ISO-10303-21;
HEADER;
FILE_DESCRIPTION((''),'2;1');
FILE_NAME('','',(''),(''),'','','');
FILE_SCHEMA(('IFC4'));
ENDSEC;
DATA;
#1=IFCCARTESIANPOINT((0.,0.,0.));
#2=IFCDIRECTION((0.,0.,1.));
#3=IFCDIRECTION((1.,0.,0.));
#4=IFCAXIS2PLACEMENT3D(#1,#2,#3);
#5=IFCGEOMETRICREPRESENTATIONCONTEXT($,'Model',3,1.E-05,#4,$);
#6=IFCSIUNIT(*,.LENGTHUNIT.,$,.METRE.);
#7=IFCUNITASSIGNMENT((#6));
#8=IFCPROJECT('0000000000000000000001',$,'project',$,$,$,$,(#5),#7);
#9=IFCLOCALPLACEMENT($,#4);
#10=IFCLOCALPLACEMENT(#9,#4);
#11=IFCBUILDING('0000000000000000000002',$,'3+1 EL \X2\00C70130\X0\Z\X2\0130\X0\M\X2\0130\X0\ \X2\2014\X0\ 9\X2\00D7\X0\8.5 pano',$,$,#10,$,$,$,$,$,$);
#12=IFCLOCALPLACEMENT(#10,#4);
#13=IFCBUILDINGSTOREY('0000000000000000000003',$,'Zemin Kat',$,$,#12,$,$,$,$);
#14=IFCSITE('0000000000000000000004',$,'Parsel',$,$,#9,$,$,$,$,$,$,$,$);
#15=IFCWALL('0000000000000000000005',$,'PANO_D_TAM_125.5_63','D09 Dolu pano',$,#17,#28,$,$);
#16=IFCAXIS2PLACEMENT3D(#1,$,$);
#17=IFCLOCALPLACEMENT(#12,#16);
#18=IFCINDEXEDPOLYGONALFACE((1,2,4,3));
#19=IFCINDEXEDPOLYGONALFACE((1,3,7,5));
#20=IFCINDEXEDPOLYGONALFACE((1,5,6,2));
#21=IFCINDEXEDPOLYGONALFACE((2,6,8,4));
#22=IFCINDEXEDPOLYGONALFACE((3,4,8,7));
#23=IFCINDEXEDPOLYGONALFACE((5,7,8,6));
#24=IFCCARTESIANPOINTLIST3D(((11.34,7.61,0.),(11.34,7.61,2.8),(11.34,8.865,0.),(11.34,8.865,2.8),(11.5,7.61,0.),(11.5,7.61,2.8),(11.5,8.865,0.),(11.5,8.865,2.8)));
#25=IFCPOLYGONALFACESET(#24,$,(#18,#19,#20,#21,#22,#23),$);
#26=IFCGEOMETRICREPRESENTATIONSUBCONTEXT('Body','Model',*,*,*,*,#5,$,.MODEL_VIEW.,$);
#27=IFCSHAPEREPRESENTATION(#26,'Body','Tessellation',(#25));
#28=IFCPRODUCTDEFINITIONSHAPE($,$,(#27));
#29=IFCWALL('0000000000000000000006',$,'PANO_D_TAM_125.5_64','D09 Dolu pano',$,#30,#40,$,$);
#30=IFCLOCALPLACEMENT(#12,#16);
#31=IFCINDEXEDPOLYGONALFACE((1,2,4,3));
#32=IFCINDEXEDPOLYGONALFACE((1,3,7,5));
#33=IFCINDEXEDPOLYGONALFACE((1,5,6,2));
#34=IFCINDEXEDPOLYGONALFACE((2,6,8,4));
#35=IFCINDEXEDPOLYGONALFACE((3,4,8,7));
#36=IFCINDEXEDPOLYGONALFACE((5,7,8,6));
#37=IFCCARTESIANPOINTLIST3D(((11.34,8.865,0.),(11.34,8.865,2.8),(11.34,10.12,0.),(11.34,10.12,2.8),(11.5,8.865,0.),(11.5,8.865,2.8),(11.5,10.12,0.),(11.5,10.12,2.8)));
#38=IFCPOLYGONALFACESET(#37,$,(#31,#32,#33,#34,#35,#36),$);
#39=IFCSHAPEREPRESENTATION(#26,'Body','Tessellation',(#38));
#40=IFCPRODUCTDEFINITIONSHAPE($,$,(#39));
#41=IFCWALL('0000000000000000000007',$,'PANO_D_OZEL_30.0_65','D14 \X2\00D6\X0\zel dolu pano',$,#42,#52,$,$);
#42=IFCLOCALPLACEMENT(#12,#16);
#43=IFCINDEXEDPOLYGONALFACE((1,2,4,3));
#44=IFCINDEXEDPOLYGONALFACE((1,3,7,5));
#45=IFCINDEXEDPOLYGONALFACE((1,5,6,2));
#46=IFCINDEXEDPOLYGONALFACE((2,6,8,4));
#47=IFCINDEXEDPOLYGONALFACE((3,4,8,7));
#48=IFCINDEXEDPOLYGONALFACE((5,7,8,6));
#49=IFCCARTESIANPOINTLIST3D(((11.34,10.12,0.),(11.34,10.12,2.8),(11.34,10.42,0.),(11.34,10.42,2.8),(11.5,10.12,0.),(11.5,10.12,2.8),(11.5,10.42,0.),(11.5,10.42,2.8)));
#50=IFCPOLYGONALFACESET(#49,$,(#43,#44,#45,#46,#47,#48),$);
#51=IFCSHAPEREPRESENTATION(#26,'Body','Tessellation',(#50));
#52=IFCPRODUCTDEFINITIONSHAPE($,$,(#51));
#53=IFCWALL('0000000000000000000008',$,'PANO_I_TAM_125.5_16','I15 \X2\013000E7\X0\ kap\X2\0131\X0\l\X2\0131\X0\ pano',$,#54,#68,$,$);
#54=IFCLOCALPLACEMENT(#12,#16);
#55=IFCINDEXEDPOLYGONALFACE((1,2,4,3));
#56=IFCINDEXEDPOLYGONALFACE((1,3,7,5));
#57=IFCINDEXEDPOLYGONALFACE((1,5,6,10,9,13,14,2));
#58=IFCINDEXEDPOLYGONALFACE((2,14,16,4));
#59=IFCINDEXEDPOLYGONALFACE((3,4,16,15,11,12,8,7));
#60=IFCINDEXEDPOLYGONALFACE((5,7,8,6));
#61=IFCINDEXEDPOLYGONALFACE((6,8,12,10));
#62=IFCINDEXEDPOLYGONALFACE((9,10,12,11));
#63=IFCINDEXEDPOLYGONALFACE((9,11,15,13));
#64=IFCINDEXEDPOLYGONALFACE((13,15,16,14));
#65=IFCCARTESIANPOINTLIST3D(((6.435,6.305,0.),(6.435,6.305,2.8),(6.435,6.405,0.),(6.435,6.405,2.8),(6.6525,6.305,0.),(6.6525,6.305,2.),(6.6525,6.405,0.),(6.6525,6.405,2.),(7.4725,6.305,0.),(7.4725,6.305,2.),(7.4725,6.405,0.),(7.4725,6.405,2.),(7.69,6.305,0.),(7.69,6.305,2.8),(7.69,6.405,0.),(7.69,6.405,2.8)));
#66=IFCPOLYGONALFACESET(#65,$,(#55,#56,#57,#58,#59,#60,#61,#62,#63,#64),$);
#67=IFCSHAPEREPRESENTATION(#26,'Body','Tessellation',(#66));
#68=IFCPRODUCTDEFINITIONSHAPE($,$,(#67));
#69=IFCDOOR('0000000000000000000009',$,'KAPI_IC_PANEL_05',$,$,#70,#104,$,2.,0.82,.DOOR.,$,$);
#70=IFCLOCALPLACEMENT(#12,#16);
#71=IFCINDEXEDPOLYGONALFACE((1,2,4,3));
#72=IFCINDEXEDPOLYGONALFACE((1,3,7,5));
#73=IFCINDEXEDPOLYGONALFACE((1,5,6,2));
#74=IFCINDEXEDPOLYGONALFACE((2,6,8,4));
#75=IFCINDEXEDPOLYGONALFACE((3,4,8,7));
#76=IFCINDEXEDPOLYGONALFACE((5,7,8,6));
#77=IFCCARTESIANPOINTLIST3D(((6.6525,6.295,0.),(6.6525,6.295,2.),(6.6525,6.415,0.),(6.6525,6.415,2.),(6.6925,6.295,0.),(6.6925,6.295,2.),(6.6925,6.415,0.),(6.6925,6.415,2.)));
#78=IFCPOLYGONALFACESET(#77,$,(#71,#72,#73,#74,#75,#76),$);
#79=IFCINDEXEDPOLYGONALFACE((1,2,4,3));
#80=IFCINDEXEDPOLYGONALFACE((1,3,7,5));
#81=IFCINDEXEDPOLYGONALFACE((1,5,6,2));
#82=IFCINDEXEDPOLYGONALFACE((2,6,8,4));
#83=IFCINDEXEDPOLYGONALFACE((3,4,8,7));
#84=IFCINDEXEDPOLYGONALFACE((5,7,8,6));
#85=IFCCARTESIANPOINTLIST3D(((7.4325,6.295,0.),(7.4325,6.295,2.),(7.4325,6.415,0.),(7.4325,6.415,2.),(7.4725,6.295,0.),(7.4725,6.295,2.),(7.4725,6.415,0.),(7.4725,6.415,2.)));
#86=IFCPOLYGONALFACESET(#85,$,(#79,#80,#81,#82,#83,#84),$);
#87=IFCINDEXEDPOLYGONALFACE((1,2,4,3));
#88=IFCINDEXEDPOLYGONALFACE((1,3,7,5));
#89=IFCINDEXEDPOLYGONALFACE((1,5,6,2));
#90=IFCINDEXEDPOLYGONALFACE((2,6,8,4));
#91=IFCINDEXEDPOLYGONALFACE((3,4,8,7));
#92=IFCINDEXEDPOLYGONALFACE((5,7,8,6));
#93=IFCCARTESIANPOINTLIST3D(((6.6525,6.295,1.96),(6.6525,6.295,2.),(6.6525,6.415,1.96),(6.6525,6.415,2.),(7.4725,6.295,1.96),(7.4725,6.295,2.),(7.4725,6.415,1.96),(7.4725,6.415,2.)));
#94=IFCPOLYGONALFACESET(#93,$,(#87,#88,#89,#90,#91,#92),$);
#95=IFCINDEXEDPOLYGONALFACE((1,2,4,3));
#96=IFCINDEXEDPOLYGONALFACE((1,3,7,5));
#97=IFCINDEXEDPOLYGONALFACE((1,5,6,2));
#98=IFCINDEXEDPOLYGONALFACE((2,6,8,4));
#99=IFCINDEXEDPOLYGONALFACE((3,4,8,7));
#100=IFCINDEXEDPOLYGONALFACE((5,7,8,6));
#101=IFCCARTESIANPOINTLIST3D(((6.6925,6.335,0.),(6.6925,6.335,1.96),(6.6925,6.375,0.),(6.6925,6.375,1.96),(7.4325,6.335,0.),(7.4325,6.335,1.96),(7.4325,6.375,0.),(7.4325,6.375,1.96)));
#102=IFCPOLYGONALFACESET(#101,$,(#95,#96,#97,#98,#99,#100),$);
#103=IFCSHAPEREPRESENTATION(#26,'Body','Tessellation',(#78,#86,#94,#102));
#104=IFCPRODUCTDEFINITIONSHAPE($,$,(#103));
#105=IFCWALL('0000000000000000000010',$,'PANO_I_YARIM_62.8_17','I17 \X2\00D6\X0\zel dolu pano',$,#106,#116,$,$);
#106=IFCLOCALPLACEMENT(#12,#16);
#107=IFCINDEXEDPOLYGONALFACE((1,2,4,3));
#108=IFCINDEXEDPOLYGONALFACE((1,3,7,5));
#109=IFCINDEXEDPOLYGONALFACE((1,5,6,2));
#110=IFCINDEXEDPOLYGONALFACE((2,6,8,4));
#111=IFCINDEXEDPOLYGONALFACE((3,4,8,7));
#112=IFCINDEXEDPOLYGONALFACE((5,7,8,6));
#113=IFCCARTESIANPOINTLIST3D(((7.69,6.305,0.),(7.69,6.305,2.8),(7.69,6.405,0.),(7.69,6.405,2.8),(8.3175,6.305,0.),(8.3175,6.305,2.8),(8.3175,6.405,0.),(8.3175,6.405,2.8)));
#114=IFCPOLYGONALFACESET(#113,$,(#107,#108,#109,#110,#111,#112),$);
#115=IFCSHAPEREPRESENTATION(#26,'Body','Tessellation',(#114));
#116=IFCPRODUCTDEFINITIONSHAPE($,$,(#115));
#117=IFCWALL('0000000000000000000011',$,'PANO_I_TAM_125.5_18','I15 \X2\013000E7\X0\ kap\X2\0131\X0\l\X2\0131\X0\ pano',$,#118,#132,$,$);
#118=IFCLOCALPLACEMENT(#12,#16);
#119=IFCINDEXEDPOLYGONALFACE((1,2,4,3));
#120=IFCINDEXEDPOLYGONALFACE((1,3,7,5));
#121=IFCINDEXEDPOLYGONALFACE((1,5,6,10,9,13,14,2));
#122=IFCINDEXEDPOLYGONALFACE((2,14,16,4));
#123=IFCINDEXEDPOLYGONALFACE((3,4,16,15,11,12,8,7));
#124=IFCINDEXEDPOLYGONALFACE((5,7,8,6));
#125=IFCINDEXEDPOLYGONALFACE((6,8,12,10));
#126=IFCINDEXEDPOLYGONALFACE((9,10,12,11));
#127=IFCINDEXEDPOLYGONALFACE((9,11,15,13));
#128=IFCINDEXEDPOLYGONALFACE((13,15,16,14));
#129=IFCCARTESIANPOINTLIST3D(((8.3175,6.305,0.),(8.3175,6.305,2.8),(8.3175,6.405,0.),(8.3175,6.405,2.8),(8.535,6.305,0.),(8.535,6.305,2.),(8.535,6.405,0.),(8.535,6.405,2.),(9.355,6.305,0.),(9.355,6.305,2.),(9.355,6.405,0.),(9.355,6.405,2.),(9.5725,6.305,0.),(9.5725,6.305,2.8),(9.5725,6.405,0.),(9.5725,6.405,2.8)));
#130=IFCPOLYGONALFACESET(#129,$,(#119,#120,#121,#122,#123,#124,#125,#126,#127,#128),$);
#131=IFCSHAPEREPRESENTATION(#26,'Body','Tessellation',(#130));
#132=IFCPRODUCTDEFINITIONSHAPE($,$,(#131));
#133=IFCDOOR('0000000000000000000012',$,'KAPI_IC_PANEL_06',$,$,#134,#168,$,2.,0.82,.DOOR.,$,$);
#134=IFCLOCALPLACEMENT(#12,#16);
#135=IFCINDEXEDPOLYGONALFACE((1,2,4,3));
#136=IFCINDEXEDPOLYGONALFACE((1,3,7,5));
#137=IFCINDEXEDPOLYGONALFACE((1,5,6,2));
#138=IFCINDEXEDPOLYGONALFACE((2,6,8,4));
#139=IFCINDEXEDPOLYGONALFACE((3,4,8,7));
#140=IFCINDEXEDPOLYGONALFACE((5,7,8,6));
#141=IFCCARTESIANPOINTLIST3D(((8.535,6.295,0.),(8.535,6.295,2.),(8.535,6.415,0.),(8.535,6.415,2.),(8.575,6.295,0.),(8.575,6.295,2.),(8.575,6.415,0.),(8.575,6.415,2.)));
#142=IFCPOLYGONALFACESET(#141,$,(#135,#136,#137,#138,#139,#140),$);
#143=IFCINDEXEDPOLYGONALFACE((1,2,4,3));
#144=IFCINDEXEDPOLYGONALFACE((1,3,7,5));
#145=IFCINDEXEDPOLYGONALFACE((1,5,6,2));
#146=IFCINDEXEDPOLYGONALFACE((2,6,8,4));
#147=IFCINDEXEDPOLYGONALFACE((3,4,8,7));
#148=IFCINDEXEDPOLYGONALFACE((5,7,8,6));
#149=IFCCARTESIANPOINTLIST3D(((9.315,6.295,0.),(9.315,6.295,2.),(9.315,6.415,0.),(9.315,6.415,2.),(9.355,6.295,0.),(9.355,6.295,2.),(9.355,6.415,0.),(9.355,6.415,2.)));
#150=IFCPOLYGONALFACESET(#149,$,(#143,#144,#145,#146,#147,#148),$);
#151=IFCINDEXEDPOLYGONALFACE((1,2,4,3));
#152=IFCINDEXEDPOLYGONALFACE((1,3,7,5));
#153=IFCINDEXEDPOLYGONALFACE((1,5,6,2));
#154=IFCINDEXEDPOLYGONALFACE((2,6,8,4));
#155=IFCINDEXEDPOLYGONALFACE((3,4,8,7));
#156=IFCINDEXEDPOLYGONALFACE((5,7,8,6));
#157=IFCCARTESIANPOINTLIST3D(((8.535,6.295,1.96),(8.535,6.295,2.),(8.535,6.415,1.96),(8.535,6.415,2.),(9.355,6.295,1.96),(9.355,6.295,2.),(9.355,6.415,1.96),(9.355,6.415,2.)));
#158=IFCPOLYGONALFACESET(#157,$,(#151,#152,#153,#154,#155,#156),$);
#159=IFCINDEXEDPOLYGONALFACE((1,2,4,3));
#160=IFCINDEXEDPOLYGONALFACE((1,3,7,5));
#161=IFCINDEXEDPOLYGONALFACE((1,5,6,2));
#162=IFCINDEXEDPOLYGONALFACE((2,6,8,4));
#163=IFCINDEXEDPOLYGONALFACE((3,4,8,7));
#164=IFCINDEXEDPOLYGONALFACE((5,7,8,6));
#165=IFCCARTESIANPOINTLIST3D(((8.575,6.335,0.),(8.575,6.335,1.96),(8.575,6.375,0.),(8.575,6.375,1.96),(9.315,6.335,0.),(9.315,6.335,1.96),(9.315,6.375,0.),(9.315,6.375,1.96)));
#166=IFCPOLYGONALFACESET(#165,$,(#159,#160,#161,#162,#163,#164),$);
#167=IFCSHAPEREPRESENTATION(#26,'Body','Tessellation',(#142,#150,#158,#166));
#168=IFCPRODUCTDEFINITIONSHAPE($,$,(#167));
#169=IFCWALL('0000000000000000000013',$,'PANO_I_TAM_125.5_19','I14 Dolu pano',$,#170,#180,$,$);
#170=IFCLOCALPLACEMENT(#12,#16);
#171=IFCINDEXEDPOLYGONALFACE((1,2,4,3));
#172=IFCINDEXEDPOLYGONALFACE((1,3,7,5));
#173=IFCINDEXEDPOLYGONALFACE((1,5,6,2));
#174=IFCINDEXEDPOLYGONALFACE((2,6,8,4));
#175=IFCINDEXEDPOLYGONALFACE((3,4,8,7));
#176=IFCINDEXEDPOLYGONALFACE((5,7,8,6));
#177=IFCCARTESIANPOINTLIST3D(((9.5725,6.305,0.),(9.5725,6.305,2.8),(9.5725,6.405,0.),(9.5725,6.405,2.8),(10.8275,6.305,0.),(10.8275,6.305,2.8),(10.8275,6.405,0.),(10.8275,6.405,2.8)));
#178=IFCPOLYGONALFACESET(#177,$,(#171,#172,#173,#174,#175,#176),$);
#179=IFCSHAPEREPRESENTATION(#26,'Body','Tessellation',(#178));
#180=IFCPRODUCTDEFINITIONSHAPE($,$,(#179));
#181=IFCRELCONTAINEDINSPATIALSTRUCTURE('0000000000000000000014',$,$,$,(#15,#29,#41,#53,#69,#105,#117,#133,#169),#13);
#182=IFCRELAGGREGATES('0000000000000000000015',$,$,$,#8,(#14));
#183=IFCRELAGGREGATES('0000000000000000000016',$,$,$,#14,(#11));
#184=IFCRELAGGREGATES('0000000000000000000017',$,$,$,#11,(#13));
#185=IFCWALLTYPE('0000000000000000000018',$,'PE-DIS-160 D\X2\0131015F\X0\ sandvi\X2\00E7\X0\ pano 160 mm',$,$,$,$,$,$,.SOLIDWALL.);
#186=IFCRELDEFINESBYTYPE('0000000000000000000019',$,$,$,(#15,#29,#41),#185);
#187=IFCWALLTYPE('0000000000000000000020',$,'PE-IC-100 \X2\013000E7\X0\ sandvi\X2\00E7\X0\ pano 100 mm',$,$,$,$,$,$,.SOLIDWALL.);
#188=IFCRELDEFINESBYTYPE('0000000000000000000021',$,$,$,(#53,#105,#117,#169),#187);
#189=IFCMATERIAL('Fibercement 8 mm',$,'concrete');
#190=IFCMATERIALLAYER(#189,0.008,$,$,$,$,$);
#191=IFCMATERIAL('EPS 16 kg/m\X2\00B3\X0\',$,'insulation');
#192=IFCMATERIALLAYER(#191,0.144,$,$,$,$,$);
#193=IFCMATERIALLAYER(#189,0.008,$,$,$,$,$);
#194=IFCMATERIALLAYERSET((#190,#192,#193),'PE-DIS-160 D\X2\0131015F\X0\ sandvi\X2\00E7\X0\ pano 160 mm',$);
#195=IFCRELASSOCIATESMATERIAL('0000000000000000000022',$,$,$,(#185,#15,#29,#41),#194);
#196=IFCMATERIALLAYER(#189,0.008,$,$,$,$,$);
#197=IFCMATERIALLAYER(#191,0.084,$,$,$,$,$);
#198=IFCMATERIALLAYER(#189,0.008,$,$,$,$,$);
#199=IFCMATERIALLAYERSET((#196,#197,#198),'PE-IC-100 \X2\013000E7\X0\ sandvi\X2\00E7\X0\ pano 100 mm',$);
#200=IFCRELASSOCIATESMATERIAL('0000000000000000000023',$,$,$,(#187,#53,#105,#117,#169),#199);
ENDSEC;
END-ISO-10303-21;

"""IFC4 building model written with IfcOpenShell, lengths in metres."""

from ifc_helpers import new_model, si_unit, frame, origin_with_axes, place, context, subcontext, project, spatial, line, indexed_curve, outline, extrude, material, layer, layer_set, layer_usage, type_object, element, fill, save


model = new_model("IFC4")

# Units and contexts
model_context = context("Model", 3, precision=1e-05, world=origin_with_axes())
body_context = subcontext(model_context, "Body", "Model", "MODEL_VIEW")
ifc_project = project(units=[si_unit("LENGTHUNIT", "METRE")], contexts=[model_context])

# Site, building, storey
site_placement = place(None, origin_with_axes())
site = spatial("IfcSite", under=ifc_project, at=site_placement, Name="Parsel")
building_placement = place(site_placement, origin_with_axes())
building = spatial("IfcBuilding", under=site, at=building_placement, Name="3+1 EL ÇİZİMİ — 9×8.5 pano")
storey_placement = place(building_placement, origin_with_axes())
storey = spatial("IfcBuildingStorey", under=building, at=storey_placement, Name="Zemin Kat")

# Shared definitions
ifc_material_1 = material(Name="Fibercement 8 mm", Category="concrete")
ifc_layer_1 = layer(ifc_material_1, 0.008)
ifc_material_2 = material(Name="EPS 16 kg/m³", Category="insulation")
ifc_layer_2 = layer(ifc_material_2, 0.144)
ifc_layer_3 = layer(ifc_material_1, 0.008)
ifc_layer_set_1 = layer_set([ifc_layer_1, ifc_layer_2, ifc_layer_3], Name="PE-DIS-160 Dış sandviç pano 160 mm")
wall_type_1 = type_object("IfcWallType", Name="PE-DIS-160 Dış sandviç pano 160 mm", PredefinedType="SOLIDWALL", material=ifc_layer_set_1)

# Walls
ifc_layer_usage_1 = layer_usage(ifc_layer_set_1, "AXIS2", "POSITIVE", 0.0)
wall_1_placement = place(storey_placement, frame((11.5, 7.61, 0.0), z_axis=(0.0, 0.0, 1.0), x_axis=(0.0, 1.0, 0.0)))
element("IfcWall", 1, at=wall_1_placement, inside=storey, type_object=wall_type_1, material=ifc_layer_usage_1, Name="PANO_D_TAM_125.5_63", Description="D09 Dolu pano", context=body_context, shape_type="SweptSolid", body=[
    extrude(outline(indexed_curve([(0.0, 0.0), (1.255, 0.0), (1.255, 0.16), (0.0, 0.16)], segments=[line(1, 2, 3, 4, 1)])), origin_with_axes(), (0.0, 0.0, 1.0), 2.8),
])
ifc_layer_usage_2 = layer_usage(ifc_layer_set_1, "AXIS2", "POSITIVE", 0.0)
wall_2_placement = place(storey_placement, frame((11.5, 8.865, 0.0), z_axis=(0.0, 0.0, 1.0), x_axis=(0.0, 1.0, 0.0)))
element("IfcWall", 2, at=wall_2_placement, inside=storey, type_object=wall_type_1, material=ifc_layer_usage_2, Name="PANO_D_TAM_125.5_64", Description="D09 Dolu pano", context=body_context, shape_type="SweptSolid", body=[
    extrude(outline(indexed_curve([(0.0, 0.0), (1.255, 0.0), (1.255, 0.16), (0.0, 0.16)], segments=[line(1, 2, 3, 4, 1)])), origin_with_axes(), (0.0, 0.0, 1.0), 2.8),
])
ifc_layer_usage_3 = layer_usage(ifc_layer_set_1, "AXIS2", "POSITIVE", 0.0)
wall_3_placement = place(storey_placement, frame((11.5, 10.12, 0.0), z_axis=(0.0, 0.0, 1.0), x_axis=(0.0, 1.0, 0.0)))
element("IfcWall", 3, at=wall_3_placement, inside=storey, type_object=wall_type_1, material=ifc_layer_usage_3, Name="PANO_D_OZEL_30.0_65", Description="D14 Özel dolu pano", context=body_context, shape_type="SweptSolid", body=[
    extrude(outline(indexed_curve([(0.0, 0.0), (0.3, 0.0), (0.3, 0.16), (0.0, 0.16)], segments=[line(1, 2, 3, 4, 1)])), origin_with_axes(), (0.0, 0.0, 1.0), 2.8),
])

# Wall, opening, door
ifc_layer_4 = layer(ifc_material_1, 0.008)
ifc_layer_5 = layer(ifc_material_2, 0.084)
ifc_layer_6 = layer(ifc_material_1, 0.008)
ifc_layer_set_2 = layer_set([ifc_layer_4, ifc_layer_5, ifc_layer_6], Name="PE-IC-100 İç sandviç pano 100 mm")
ifc_layer_usage_4 = layer_usage(ifc_layer_set_2, "AXIS2", "POSITIVE", 0.0)
wall_type_2 = type_object("IfcWallType", Name="PE-IC-100 İç sandviç pano 100 mm", PredefinedType="SOLIDWALL", material=ifc_layer_set_2)
wall_4_placement = place(storey_placement, frame((6.435, 6.305, 0.0), z_axis=(0.0, 0.0, 1.0), x_axis=(1.0, 0.0, 0.0)))
wall_4 = element("IfcWall", 4, at=wall_4_placement, inside=storey, type_object=wall_type_2, material=ifc_layer_usage_4, Name="PANO_I_TAM_125.5_16", Description="I15 İç kapılı pano", context=body_context, shape_type="SweptSolid", body=[
    extrude(outline(indexed_curve([(0.0, 0.0), (1.255, 0.0), (1.255, 0.1), (0.0, 0.1)], segments=[line(1, 2, 3, 4, 1)])), origin_with_axes(), (0.0, 0.0, 1.0), 2.8),
])
opening_1_placement = place(wall_4_placement, origin_with_axes())
opening_1 = element("IfcOpeningElement", 5, at=opening_1_placement, cuts=wall_4, PredefinedType="OPENING", context=body_context, shape_type="SweptSolid", body=[
    extrude(outline(indexed_curve([(0.0, 0.0), (0.82, 0.0), (0.82, 0.14), (0.0, 0.14)], segments=[line(1, 2, 3, 4, 1)])), frame((0.2175, -0.02, 0.0), z_axis=(0.0, 0.0, 1.0), x_axis=(1.0, 0.0, 0.0)), (0.0, 0.0, 1.0), 2.0),
])
door_1_placement = place(storey_placement, frame((6.435, 6.305, 0.0), z_axis=(0.0, 0.0, 1.0), x_axis=(1.0, 0.0, 0.0)))
door_1 = element("IfcDoor", 6, at=door_1_placement, inside=storey, Name="KAPI_IC_PANEL_05", OverallHeight=2.0, OverallWidth=0.82, PredefinedType="DOOR", context=body_context, shape_type="SweptSolid", body=[
    extrude(outline(indexed_curve([(0.0, 0.0), (0.04, 0.0), (0.04, 0.12), (0.0, 0.12)], segments=[line(1, 2, 3, 4, 1)])), frame((0.2175, -0.01, 0.0), z_axis=(0.0, 0.0, 1.0), x_axis=(1.0, 0.0, 0.0)), (0.0, 0.0, 1.0), 2.0),
    extrude(outline(indexed_curve([(0.0, 0.0), (0.04, 0.0), (0.04, 0.12), (0.0, 0.12)], segments=[line(1, 2, 3, 4, 1)])), frame((0.9975, -0.01, 0.0), z_axis=(0.0, 0.0, 1.0), x_axis=(1.0, 0.0, 0.0)), (0.0, 0.0, 1.0), 2.0),
    extrude(outline(indexed_curve([(0.0, 0.0), (0.82, 0.0), (0.82, 0.12), (0.0, 0.12)], segments=[line(1, 2, 3, 4, 1)])), frame((0.2175, -0.01, 1.96), z_axis=(0.0, 0.0, 1.0), x_axis=(1.0, 0.0, 0.0)), (0.0, 0.0, 1.0), 0.04),
    extrude(outline(indexed_curve([(0.0, 0.0), (0.74, 0.0), (0.74, 0.04), (0.0, 0.04)], segments=[line(1, 2, 3, 4, 1)])), frame((0.2575, 0.03, 0.0), z_axis=(0.0, 0.0, 1.0), x_axis=(1.0, 0.0, 0.0)), (0.0, 0.0, 1.0), 1.96),
])
fill(opening_1, door_1)

# Wall
ifc_layer_usage_5 = layer_usage(ifc_layer_set_2, "AXIS2", "POSITIVE", 0.0)
wall_5_placement = place(storey_placement, frame((7.69, 6.305, 0.0), z_axis=(0.0, 0.0, 1.0), x_axis=(1.0, 0.0, 0.0)))
element("IfcWall", 7, at=wall_5_placement, inside=storey, type_object=wall_type_2, material=ifc_layer_usage_5, Name="PANO_I_YARIM_62.8_17", Description="I17 Özel dolu pano", context=body_context, shape_type="SweptSolid", body=[
    extrude(outline(indexed_curve([(0.0, 0.0), (0.6275, 0.0), (0.6275, 0.1), (0.0, 0.1)], segments=[line(1, 2, 3, 4, 1)])), origin_with_axes(), (0.0, 0.0, 1.0), 2.8),
])

# Wall, opening, door
ifc_layer_usage_6 = layer_usage(ifc_layer_set_2, "AXIS2", "POSITIVE", 0.0)
wall_6_placement = place(storey_placement, frame((8.3175, 6.305, 0.0), z_axis=(0.0, 0.0, 1.0), x_axis=(1.0, 0.0, 0.0)))
wall_6 = element("IfcWall", 8, at=wall_6_placement, inside=storey, type_object=wall_type_2, material=ifc_layer_usage_6, Name="PANO_I_TAM_125.5_18", Description="I15 İç kapılı pano", context=body_context, shape_type="SweptSolid", body=[
    extrude(outline(indexed_curve([(0.0, 0.0), (1.255, 0.0), (1.255, 0.1), (0.0, 0.1)], segments=[line(1, 2, 3, 4, 1)])), origin_with_axes(), (0.0, 0.0, 1.0), 2.8),
])
opening_2_placement = place(wall_6_placement, origin_with_axes())
opening_2 = element("IfcOpeningElement", 9, at=opening_2_placement, cuts=wall_6, PredefinedType="OPENING", context=body_context, shape_type="SweptSolid", body=[
    extrude(outline(indexed_curve([(0.0, 0.0), (0.82, 0.0), (0.82, 0.14), (0.0, 0.14)], segments=[line(1, 2, 3, 4, 1)])), frame((0.2175, -0.02, 0.0), z_axis=(0.0, 0.0, 1.0), x_axis=(1.0, 0.0, 0.0)), (0.0, 0.0, 1.0), 2.0),
])
door_2_placement = place(storey_placement, frame((8.3175, 6.305, 0.0), z_axis=(0.0, 0.0, 1.0), x_axis=(1.0, 0.0, 0.0)))
door_2 = element("IfcDoor", 10, at=door_2_placement, inside=storey, Name="KAPI_IC_PANEL_06", OverallHeight=2.0, OverallWidth=0.82, PredefinedType="DOOR", context=body_context, shape_type="SweptSolid", body=[
    extrude(outline(indexed_curve([(0.0, 0.0), (0.04, 0.0), (0.04, 0.12), (0.0, 0.12)], segments=[line(1, 2, 3, 4, 1)])), frame((0.2175, -0.01, 0.0), z_axis=(0.0, 0.0, 1.0), x_axis=(1.0, 0.0, 0.0)), (0.0, 0.0, 1.0), 2.0),
    extrude(outline(indexed_curve([(0.0, 0.0), (0.04, 0.0), (0.04, 0.12), (0.0, 0.12)], segments=[line(1, 2, 3, 4, 1)])), frame((0.9975, -0.01, 0.0), z_axis=(0.0, 0.0, 1.0), x_axis=(1.0, 0.0, 0.0)), (0.0, 0.0, 1.0), 2.0),
    extrude(outline(indexed_curve([(0.0, 0.0), (0.82, 0.0), (0.82, 0.12), (0.0, 0.12)], segments=[line(1, 2, 3, 4, 1)])), frame((0.2175, -0.01, 1.96), z_axis=(0.0, 0.0, 1.0), x_axis=(1.0, 0.0, 0.0)), (0.0, 0.0, 1.0), 0.04),
    extrude(outline(indexed_curve([(0.0, 0.0), (0.74, 0.0), (0.74, 0.04), (0.0, 0.04)], segments=[line(1, 2, 3, 4, 1)])), frame((0.2575, 0.03, 0.0), z_axis=(0.0, 0.0, 1.0), x_axis=(1.0, 0.0, 0.0)), (0.0, 0.0, 1.0), 1.96),
])
fill(opening_2, door_2)

# Wall
ifc_layer_usage_7 = layer_usage(ifc_layer_set_2, "AXIS2", "POSITIVE", 0.0)
wall_7_placement = place(storey_placement, frame((9.5725, 6.305, 0.0), z_axis=(0.0, 0.0, 1.0), x_axis=(1.0, 0.0, 0.0)))
element("IfcWall", 11, at=wall_7_placement, inside=storey, type_object=wall_type_2, material=ifc_layer_usage_7, Name="PANO_I_TAM_125.5_19", Description="I14 Dolu pano", context=body_context, shape_type="SweptSolid", body=[
    extrude(outline(indexed_curve([(0.0, 0.0), (1.255, 0.0), (1.255, 0.1), (0.0, 0.1)], segments=[line(1, 2, 3, 4, 1)])), origin_with_axes(), (0.0, 0.0, 1.0), 2.8),
])

save(model, "model.ifc")
